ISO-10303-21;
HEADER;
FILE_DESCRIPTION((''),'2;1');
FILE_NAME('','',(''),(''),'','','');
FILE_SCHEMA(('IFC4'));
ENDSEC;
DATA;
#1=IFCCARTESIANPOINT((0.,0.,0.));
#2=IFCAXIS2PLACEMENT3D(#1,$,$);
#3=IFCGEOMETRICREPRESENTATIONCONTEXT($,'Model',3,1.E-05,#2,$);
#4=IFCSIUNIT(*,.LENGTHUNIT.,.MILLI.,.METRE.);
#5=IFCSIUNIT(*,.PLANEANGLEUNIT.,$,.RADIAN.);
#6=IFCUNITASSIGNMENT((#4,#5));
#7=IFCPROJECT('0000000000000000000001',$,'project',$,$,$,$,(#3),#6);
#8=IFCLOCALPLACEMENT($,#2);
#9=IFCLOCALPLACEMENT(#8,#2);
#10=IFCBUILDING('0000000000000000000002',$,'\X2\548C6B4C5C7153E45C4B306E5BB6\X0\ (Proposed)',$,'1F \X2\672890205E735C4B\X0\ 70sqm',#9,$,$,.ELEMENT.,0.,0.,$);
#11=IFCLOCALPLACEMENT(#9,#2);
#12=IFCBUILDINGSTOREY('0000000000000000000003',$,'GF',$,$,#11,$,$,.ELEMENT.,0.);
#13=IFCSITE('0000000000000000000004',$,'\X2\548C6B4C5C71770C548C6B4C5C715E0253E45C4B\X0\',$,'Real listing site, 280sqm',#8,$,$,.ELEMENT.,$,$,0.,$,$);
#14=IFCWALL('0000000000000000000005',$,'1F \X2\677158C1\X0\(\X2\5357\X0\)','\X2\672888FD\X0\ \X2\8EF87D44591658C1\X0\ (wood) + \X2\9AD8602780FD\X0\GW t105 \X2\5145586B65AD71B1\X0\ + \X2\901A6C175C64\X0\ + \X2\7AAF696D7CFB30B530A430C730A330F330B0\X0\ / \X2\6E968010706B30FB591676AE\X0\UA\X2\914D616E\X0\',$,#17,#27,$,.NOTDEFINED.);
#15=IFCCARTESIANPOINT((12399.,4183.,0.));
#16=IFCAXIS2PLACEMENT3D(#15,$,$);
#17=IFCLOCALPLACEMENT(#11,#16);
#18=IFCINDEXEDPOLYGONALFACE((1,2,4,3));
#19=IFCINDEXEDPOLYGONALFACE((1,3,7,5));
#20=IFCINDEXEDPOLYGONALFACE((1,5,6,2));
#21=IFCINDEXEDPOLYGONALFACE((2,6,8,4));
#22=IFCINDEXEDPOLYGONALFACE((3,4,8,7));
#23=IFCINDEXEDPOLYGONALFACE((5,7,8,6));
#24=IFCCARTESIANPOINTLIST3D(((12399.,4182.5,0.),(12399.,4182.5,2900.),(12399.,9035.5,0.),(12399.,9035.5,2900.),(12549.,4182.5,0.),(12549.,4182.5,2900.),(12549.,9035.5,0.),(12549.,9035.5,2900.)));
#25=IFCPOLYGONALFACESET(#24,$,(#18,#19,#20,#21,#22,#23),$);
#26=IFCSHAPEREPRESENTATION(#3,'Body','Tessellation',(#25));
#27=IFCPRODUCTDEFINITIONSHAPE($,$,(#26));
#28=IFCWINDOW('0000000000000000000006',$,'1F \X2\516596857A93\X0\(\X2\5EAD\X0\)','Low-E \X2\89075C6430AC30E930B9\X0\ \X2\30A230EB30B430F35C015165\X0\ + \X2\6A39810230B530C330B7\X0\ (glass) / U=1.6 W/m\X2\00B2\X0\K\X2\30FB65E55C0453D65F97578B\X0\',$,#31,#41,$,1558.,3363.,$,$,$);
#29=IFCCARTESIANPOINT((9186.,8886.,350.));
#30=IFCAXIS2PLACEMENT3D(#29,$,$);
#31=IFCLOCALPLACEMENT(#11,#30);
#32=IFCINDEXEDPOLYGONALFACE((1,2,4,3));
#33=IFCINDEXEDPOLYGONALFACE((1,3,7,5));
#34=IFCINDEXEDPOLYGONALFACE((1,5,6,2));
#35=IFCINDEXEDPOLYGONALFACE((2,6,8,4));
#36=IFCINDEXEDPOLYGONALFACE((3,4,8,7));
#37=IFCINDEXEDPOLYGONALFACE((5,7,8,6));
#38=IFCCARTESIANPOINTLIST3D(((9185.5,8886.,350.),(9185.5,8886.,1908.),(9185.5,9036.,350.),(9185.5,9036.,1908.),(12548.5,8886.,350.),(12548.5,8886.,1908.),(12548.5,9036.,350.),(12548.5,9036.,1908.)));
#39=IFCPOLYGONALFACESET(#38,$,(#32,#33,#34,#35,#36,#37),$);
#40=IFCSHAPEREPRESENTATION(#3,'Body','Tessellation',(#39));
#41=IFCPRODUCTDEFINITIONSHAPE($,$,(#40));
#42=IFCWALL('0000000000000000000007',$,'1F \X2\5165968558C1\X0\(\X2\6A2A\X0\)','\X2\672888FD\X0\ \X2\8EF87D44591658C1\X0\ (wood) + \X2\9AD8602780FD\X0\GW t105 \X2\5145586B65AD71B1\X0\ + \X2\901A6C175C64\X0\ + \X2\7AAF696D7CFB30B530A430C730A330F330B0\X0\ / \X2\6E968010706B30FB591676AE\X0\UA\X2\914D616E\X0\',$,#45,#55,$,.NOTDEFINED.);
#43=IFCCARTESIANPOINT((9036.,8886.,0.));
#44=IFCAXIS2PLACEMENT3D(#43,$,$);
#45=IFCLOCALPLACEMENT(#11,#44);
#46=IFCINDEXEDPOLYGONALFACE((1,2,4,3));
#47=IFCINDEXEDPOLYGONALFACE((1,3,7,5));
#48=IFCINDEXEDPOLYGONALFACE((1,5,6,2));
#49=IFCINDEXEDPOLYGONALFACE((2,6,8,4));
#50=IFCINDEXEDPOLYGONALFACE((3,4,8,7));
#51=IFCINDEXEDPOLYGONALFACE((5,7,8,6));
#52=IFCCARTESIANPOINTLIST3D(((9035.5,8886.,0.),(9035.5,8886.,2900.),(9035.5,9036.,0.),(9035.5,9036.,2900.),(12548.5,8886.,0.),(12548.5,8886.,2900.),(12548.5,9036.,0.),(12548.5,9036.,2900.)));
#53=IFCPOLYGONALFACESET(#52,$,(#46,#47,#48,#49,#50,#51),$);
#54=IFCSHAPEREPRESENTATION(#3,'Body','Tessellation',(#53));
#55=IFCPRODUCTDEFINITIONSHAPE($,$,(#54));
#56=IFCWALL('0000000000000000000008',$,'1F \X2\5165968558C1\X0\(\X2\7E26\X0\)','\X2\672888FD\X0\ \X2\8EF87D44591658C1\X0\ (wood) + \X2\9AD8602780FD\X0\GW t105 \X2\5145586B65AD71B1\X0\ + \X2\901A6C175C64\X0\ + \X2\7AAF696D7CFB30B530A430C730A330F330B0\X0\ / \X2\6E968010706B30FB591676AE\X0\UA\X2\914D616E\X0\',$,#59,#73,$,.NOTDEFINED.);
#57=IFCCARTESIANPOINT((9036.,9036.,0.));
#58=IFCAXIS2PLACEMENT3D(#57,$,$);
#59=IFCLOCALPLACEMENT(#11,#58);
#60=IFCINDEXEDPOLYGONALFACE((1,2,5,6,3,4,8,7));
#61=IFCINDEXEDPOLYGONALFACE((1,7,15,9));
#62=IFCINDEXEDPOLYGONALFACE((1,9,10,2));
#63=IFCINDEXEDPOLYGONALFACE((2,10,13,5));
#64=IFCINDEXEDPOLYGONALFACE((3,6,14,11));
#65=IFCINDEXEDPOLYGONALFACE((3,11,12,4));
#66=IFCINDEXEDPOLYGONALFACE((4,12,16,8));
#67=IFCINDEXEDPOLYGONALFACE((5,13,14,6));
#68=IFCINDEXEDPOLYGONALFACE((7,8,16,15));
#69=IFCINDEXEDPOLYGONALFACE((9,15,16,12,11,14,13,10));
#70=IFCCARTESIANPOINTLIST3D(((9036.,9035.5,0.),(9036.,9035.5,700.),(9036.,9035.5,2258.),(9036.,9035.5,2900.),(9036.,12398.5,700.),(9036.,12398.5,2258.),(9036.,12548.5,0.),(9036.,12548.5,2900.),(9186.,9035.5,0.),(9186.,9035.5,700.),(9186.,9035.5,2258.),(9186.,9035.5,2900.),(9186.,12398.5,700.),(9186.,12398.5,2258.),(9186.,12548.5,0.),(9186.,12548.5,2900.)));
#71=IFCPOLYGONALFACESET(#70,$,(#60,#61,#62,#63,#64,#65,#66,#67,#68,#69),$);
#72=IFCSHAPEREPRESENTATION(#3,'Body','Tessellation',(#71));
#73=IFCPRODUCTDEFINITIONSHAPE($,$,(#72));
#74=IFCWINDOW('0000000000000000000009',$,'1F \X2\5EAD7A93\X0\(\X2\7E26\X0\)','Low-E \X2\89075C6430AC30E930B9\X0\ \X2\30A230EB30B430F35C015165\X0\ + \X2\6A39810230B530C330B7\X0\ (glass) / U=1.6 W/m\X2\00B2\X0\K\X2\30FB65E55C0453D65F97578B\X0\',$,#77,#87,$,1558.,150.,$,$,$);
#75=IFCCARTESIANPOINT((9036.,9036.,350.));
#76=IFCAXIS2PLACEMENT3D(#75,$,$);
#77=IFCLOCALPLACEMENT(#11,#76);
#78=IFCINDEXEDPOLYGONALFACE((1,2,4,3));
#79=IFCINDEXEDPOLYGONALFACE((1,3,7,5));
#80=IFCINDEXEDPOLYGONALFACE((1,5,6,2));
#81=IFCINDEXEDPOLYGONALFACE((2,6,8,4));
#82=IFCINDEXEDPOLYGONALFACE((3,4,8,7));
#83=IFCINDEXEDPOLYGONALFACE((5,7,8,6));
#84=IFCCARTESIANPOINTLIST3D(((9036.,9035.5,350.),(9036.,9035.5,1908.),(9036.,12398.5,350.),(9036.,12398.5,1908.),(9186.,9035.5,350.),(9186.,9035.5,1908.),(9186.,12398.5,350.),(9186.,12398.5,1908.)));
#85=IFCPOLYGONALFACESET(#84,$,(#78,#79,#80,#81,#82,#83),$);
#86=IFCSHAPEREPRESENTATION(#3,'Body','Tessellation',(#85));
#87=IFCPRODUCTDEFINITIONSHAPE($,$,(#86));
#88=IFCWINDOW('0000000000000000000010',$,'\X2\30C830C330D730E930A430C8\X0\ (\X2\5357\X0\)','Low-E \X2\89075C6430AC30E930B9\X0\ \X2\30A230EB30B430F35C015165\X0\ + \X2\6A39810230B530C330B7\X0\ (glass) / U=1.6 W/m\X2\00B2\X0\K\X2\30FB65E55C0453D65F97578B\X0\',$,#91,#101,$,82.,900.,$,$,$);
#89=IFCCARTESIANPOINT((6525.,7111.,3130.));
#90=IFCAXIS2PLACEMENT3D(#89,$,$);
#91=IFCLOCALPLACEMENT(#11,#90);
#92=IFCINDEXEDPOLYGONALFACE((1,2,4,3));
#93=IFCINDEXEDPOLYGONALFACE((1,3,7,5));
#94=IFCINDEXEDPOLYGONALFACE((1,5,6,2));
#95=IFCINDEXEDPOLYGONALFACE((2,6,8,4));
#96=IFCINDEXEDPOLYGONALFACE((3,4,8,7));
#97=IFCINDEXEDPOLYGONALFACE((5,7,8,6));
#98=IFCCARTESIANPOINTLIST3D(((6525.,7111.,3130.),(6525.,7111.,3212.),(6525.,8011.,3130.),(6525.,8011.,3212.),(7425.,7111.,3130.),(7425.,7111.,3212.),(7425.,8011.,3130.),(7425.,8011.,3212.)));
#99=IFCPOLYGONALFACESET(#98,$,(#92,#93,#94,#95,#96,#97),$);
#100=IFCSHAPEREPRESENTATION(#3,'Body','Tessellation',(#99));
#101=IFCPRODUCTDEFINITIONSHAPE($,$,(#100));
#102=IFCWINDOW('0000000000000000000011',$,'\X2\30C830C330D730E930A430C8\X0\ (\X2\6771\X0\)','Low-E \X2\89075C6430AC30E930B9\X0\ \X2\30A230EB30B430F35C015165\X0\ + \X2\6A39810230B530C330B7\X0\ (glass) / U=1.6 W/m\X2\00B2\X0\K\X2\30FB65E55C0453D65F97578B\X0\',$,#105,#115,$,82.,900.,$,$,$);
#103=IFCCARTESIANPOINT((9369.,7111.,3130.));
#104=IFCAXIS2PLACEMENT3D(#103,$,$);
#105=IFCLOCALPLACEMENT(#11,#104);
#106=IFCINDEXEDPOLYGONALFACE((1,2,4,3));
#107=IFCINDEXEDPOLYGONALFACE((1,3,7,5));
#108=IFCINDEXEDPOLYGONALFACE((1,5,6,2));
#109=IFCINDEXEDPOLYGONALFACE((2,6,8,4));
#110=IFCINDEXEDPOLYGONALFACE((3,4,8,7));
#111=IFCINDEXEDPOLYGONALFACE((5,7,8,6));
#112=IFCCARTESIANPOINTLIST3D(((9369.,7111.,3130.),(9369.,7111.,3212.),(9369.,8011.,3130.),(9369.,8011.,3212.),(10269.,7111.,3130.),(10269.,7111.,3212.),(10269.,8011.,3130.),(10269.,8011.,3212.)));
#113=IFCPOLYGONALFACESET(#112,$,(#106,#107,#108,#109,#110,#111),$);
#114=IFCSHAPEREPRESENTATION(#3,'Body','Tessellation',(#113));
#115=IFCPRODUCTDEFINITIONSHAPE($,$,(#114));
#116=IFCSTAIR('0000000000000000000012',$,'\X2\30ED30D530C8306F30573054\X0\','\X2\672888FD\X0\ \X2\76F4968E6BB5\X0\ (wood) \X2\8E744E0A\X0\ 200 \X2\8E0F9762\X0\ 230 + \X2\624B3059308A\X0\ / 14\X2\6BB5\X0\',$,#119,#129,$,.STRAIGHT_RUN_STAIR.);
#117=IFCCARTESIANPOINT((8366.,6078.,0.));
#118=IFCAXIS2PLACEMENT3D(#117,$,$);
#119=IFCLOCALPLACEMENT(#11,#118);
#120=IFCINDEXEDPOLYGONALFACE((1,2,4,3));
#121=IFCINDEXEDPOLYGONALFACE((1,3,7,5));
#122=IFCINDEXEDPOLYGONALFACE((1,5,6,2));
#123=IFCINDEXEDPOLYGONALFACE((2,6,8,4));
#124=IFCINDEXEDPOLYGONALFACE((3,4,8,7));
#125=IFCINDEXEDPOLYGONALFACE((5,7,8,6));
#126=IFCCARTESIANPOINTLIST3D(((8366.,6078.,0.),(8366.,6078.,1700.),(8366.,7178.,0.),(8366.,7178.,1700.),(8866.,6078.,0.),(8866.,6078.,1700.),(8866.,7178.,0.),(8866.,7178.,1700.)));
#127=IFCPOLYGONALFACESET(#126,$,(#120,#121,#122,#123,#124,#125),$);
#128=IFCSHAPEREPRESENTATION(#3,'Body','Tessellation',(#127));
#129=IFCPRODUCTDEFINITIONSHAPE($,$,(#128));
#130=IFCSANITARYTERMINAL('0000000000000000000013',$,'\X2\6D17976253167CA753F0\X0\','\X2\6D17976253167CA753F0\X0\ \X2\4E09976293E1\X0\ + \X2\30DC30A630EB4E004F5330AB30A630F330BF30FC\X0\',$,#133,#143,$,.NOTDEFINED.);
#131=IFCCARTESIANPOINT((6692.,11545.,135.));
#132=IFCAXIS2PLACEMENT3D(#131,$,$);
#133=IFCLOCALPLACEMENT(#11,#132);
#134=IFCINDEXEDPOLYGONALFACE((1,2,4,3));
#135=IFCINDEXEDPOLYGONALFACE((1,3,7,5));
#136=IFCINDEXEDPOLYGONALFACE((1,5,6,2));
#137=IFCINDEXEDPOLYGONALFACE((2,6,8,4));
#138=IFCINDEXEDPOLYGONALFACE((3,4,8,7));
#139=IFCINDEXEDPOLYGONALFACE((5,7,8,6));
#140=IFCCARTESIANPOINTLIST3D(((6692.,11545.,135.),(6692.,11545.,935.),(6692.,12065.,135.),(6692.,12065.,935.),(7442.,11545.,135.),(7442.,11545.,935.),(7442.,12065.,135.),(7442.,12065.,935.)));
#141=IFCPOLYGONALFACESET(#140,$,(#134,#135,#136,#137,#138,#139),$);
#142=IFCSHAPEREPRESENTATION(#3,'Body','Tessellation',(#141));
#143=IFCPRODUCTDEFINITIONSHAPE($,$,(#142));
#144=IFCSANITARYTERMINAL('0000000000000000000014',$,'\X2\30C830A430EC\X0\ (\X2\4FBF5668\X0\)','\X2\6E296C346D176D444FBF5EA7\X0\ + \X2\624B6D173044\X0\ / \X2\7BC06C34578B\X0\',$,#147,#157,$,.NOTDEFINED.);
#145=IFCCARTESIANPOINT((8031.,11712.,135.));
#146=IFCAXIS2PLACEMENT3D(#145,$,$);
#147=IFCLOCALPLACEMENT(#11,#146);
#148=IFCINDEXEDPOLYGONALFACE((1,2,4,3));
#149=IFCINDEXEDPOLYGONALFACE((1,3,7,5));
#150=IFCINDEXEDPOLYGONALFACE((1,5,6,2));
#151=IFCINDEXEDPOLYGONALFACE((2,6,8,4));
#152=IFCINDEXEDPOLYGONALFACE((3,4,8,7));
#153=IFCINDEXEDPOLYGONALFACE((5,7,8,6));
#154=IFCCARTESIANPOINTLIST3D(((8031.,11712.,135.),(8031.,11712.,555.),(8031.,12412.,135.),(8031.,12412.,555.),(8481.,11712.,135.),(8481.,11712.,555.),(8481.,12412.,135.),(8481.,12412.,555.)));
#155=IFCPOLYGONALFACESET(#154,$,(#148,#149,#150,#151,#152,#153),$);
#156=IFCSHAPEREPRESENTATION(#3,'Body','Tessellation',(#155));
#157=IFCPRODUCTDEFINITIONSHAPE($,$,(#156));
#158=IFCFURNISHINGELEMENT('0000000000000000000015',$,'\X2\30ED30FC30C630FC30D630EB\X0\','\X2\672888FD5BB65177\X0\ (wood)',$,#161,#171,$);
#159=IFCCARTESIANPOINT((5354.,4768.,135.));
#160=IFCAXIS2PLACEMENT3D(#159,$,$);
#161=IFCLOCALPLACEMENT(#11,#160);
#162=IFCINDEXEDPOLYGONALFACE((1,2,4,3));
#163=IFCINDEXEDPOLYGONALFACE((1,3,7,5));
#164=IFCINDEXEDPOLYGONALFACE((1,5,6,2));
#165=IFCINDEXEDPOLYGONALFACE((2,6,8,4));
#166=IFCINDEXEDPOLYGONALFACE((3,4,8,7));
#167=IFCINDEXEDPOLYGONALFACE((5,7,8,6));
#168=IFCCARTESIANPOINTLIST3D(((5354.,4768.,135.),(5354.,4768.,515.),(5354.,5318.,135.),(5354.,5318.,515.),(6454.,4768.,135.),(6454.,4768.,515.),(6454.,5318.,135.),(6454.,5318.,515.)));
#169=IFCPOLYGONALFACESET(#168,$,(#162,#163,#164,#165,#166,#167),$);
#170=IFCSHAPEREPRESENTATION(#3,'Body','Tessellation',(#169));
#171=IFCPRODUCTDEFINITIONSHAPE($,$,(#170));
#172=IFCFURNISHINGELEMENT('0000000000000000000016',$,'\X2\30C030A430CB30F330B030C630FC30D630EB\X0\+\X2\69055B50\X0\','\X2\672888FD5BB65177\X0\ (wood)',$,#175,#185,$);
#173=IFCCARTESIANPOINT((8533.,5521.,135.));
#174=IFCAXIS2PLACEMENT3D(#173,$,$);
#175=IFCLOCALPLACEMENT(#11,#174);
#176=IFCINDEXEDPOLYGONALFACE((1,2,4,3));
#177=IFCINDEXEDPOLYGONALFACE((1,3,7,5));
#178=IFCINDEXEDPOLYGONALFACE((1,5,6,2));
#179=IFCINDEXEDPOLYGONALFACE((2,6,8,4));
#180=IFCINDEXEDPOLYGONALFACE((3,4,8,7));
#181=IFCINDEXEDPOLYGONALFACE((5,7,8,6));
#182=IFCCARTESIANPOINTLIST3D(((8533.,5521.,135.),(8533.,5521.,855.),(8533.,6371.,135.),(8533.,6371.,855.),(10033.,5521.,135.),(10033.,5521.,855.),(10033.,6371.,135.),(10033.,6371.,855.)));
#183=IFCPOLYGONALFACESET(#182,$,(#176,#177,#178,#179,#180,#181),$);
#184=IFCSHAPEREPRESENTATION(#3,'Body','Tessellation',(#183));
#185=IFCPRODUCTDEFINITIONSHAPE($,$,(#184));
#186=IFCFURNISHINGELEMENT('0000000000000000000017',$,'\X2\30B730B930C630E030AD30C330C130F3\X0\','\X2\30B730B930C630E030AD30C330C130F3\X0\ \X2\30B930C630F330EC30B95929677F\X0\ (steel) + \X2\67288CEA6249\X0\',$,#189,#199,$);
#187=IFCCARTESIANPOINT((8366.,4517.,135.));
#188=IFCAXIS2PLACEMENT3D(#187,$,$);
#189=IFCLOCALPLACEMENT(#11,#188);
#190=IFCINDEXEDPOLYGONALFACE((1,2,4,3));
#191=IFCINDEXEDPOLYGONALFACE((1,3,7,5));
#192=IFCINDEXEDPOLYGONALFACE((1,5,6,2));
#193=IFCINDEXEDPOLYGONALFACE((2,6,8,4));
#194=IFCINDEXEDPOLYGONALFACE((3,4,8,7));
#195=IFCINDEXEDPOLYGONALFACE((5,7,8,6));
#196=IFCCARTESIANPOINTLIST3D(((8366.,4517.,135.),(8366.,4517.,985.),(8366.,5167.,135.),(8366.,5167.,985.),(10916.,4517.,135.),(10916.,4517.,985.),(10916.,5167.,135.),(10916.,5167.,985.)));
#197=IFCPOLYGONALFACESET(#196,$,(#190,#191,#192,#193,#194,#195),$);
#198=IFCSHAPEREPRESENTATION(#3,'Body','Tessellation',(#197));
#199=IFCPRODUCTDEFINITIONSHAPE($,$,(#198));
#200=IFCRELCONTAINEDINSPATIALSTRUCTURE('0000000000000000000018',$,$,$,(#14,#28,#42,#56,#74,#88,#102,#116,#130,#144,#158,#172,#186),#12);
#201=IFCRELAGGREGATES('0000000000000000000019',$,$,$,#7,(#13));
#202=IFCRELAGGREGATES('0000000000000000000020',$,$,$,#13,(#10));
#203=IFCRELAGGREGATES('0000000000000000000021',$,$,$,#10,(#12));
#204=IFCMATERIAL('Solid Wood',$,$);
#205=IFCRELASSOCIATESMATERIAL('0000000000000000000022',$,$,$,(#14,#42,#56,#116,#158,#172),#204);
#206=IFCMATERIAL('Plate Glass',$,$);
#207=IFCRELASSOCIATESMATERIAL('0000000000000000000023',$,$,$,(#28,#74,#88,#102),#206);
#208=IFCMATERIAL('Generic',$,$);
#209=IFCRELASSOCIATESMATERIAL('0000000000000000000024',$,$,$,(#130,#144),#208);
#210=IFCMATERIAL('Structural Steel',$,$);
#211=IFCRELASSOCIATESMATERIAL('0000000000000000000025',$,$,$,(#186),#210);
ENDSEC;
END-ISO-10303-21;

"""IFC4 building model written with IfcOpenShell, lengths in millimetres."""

from ifc_helpers import new_model, si_unit, frame, frame_2d, origin, place, context, project, spatial, rectangle, extrude, material, element, fill, save


model = new_model("IFC4")

# Units and contexts
model_context = context("Model", 3, precision=1e-05, world=origin())
ifc_project = project(units=[si_unit("LENGTHUNIT", "METRE", prefix="MILLI"), si_unit("PLANEANGLEUNIT", "RADIAN")], contexts=[model_context])

# Site, building, storey
site_placement = place(None, origin())
site = spatial("IfcSite", under=ifc_project, at=site_placement, Name="和歌山県和歌山市古屋", ObjectType="Real listing site, 280sqm", CompositionType="ELEMENT", RefElevation=0.0)
building_placement = place(site_placement, origin())
building = spatial("IfcBuilding", under=site, at=building_placement, Name="和歌山古屋の家 (Proposed)", ObjectType="1F 木造平屋 70sqm", CompositionType="ELEMENT", ElevationOfRefHeight=0.0, ElevationOfTerrain=0.0)
storey_placement = place(building_placement, origin())
storey = spatial("IfcBuildingStorey", under=building, at=storey_placement, Name="GF", CompositionType="ELEMENT", Elevation=0.0)

# Shared definitions
ifc_material_1 = material(Name="Solid Wood")

# Wall, opening, window
wall_1_placement = place(storey_placement, frame((12399.0, 4183.0, 0.0)))
wall_1 = element("IfcWall", 1, at=wall_1_placement, inside=storey, material=ifc_material_1, Name="1F 東壁(南)", Description="木製 軸組外壁 (wood) + 高性能GW t105 充填断熱 + 通気層 + 窯業系サイディング / 準耐火・外皮UA配慮", PredefinedType="NOTDEFINED", context=model_context, shape_type="SweptSolid", body=[
    extrude(rectangle(XDim=150.0, YDim=4853.0, at=frame_2d((75.0, 2426.0))), frame((12399.0, 4183.0, 0.0)), (0.0, 0.0, 1.0), 2900.0),
])
opening_1_placement = place(storey_placement, frame((9186.0, 8886.0, 350.0)))
opening_1 = element("IfcOpeningElement", 2, at=opening_1_placement, cuts=wall_1, PredefinedType="NOTDEFINED", context=model_context, shape_type="SweptSolid", body=[
    extrude(rectangle(XDim=3363.0, YDim=150.0, at=frame_2d((1681.0, 75.0))), frame((9186.0, 8886.0, 350.0)), (0.0, 0.0, 1.0), 1558.0),
])
ifc_material_2 = material(Name="Plate Glass")
window_1_placement = place(storey_placement, frame((9186.0, 8886.0, 350.0)))
window_1 = element("IfcWindow", 3, at=window_1_placement, inside=storey, material=ifc_material_2, Name="1F 入隅窓(庭)", Description="Low-E 複層ガラス アルゴン封入 + 樹脂サッシ (glass) / U=1.6 W/m²K・日射取得型", OverallHeight=1558.0, OverallWidth=3363.0, context=model_context, shape_type="SweptSolid", body=[
    extrude(rectangle(XDim=3363.0, YDim=150.0, at=frame_2d((1681.0, 75.0))), frame((9186.0, 8886.0, 350.0)), (0.0, 0.0, 1.0), 1558.0),
])
fill(opening_1, window_1)

# Wall
wall_2_placement = place(storey_placement, frame((9036.0, 8886.0, 0.0)))
element("IfcWall", 4, at=wall_2_placement, inside=storey, material=ifc_material_1, Name="1F 入隅壁(横)", Description="木製 軸組外壁 (wood) + 高性能GW t105 充填断熱 + 通気層 + 窯業系サイディング / 準耐火・外皮UA配慮", PredefinedType="NOTDEFINED", context=model_context, shape_type="SweptSolid", body=[
    extrude(rectangle(XDim=3513.0, YDim=150.0, at=frame_2d((1756.0, 75.0))), frame((9036.0, 8886.0, 0.0)), (0.0, 0.0, 1.0), 2900.0),
])

# Wall, opening, window
wall_3_placement = place(storey_placement, frame((9036.0, 9036.0, 0.0)))
wall_3 = element("IfcWall", 5, at=wall_3_placement, inside=storey, material=ifc_material_1, Name="1F 入隅壁(縦)", Description="木製 軸組外壁 (wood) + 高性能GW t105 充填断熱 + 通気層 + 窯業系サイディング / 準耐火・外皮UA配慮", PredefinedType="NOTDEFINED", context=model_context, shape_type="SweptSolid", body=[
    extrude(rectangle(XDim=150.0, YDim=3513.0, at=frame_2d((75.0, 1756.0))), frame((9036.0, 9036.0, 0.0)), (0.0, 0.0, 1.0), 2900.0),
])
opening_2_placement = place(storey_placement, frame((9036.0, 9036.0, 350.0)))
opening_2 = element("IfcOpeningElement", 6, at=opening_2_placement, cuts=wall_3, PredefinedType="NOTDEFINED", context=model_context, shape_type="SweptSolid", body=[
    extrude(rectangle(XDim=150.0, YDim=3363.0, at=frame_2d((75.0, 1681.0))), frame((9036.0, 9036.0, 350.0)), (0.0, 0.0, 1.0), 1558.0),
])
window_2_placement = place(storey_placement, frame((9036.0, 9036.0, 350.0)))
window_2 = element("IfcWindow", 7, at=window_2_placement, inside=storey, material=ifc_material_2, Name="1F 庭窓(縦)", Description="Low-E 複層ガラス アルゴン封入 + 樹脂サッシ (glass) / U=1.6 W/m²K・日射取得型", OverallHeight=1558.0, OverallWidth=150.0, context=model_context, shape_type="SweptSolid", body=[
    extrude(rectangle(XDim=150.0, YDim=3363.0, at=frame_2d((75.0, 1681.0))), frame((9036.0, 9036.0, 350.0)), (0.0, 0.0, 1.0), 1558.0),
])
fill(opening_2, window_2)

# Windows
window_3_placement = place(storey_placement, frame((6525.0, 7111.0, 3130.0)))
element("IfcWindow", 8, at=window_3_placement, inside=storey, material=ifc_material_2, Name="トップライト (南)", Description="Low-E 複層ガラス アルゴン封入 + 樹脂サッシ (glass) / U=1.6 W/m²K・日射取得型", OverallHeight=82.0, OverallWidth=900.0, context=model_context, shape_type="SweptSolid", body=[
    extrude(rectangle(XDim=900.0, YDim=900.0, at=frame_2d((450.0, 450.0))), frame((6525.0, 7111.0, 3130.0)), (0.0, 0.0, 1.0), 82.0),
])
window_4_placement = place(storey_placement, frame((9369.0, 7111.0, 3130.0)))
element("IfcWindow", 9, at=window_4_placement, inside=storey, material=ifc_material_2, Name="トップライト (東)", Description="Low-E 複層ガラス アルゴン封入 + 樹脂サッシ (glass) / U=1.6 W/m²K・日射取得型", OverallHeight=82.0, OverallWidth=900.0, context=model_context, shape_type="SweptSolid", body=[
    extrude(rectangle(XDim=900.0, YDim=900.0, at=frame_2d((450.0, 450.0))), frame((9369.0, 7111.0, 3130.0)), (0.0, 0.0, 1.0), 82.0),
])

# Stair
stair_placement = place(storey_placement, frame((8366.0, 6078.0, 0.0)))
element("IfcStair", 10, at=stair_placement, inside=storey, material=ifc_material_1, Name="ロフトはしご", Description="木製 直階段 (wood) 蹴上 200 踏面 230 + 手すり / 14段", PredefinedType="STRAIGHT_RUN_STAIR", context=model_context, shape_type="SweptSolid", body=[
    extrude(rectangle(XDim=500.0, YDim=1100.0, at=frame_2d((250.0, 550.0))), frame((8366.0, 6078.0, 0.0)), (0.0, 0.0, 1.0), 1700.0),
])

# Sanitary terminals
ifc_material_3 = material(Name="Generic")
sanitary_terminal_1_placement = place(storey_placement, frame((6692.0, 11545.0, 135.0)))
element("IfcSanitaryTerminal", 11, at=sanitary_terminal_1_placement, inside=storey, material=ifc_material_3, Name="洗面化粧台", Description="洗面化粧台 三面鏡 + ボウル一体カウンター", PredefinedType="NOTDEFINED", context=model_context, shape_type="SweptSolid", body=[
    extrude(rectangle(XDim=750.0, YDim=520.0, at=frame_2d((375.0, 260.0))), frame((6692.0, 11545.0, 135.0)), (0.0, 0.0, 1.0), 800.0),
])
sanitary_terminal_2_placement = place(storey_placement, frame((8031.0, 11712.0, 135.0)))
element("IfcSanitaryTerminal", 12, at=sanitary_terminal_2_placement, inside=storey, material=ifc_material_3, Name="トイレ (便器)", Description="温水洗浄便座 + 手洗い / 節水型", PredefinedType="NOTDEFINED", context=model_context, shape_type="SweptSolid", body=[
    extrude(rectangle(XDim=450.0, YDim=700.0, at=frame_2d((225.0, 350.0))), frame((8031.0, 11712.0, 135.0)), (0.0, 0.0, 1.0), 420.0),
])

# Furnishing elements
furnishing_1_placement = place(storey_placement, frame((5354.0, 4768.0, 135.0)))
element("IfcFurnishingElement", 13, at=furnishing_1_placement, inside=storey, material=ifc_material_1, Name="ローテーブル", Description="木製家具 (wood)", context=model_context, shape_type="SweptSolid", body=[
    extrude(rectangle(XDim=1100.0, YDim=550.0, at=frame_2d((550.0, 275.0))), frame((5354.0, 4768.0, 135.0)), (0.0, 0.0, 1.0), 380.0),
])
furnishing_2_placement = place(storey_placement, frame((8533.0, 5521.0, 135.0)))
element("IfcFurnishingElement", 14, at=furnishing_2_placement, inside=storey, material=ifc_material_1, Name="ダイニングテーブル+椅子", Description="木製家具 (wood)", context=model_context, shape_type="SweptSolid", body=[
    extrude(rectangle(XDim=1500.0, YDim=850.0, at=frame_2d((750.0, 425.0))), frame((8533.0, 5521.0, 135.0)), (0.0, 0.0, 1.0), 720.0),
])
ifc_material_4 = material(Name="Structural Steel")
furnishing_3_placement = place(storey_placement, frame((8366.0, 4517.0, 135.0)))
element("IfcFurnishingElement", 15, at=furnishing_3_placement, inside=storey, material=ifc_material_4, Name="システムキッチン", Description="システムキッチン ステンレス天板 (steel) + 木質扉", context=model_context, shape_type="SweptSolid", body=[
    extrude(rectangle(XDim=2550.0, YDim=650.0, at=frame_2d((1275.0, 325.0))), frame((8366.0, 4517.0, 135.0)), (0.0, 0.0, 1.0), 850.0),
])

save(model, "model.ifc")
